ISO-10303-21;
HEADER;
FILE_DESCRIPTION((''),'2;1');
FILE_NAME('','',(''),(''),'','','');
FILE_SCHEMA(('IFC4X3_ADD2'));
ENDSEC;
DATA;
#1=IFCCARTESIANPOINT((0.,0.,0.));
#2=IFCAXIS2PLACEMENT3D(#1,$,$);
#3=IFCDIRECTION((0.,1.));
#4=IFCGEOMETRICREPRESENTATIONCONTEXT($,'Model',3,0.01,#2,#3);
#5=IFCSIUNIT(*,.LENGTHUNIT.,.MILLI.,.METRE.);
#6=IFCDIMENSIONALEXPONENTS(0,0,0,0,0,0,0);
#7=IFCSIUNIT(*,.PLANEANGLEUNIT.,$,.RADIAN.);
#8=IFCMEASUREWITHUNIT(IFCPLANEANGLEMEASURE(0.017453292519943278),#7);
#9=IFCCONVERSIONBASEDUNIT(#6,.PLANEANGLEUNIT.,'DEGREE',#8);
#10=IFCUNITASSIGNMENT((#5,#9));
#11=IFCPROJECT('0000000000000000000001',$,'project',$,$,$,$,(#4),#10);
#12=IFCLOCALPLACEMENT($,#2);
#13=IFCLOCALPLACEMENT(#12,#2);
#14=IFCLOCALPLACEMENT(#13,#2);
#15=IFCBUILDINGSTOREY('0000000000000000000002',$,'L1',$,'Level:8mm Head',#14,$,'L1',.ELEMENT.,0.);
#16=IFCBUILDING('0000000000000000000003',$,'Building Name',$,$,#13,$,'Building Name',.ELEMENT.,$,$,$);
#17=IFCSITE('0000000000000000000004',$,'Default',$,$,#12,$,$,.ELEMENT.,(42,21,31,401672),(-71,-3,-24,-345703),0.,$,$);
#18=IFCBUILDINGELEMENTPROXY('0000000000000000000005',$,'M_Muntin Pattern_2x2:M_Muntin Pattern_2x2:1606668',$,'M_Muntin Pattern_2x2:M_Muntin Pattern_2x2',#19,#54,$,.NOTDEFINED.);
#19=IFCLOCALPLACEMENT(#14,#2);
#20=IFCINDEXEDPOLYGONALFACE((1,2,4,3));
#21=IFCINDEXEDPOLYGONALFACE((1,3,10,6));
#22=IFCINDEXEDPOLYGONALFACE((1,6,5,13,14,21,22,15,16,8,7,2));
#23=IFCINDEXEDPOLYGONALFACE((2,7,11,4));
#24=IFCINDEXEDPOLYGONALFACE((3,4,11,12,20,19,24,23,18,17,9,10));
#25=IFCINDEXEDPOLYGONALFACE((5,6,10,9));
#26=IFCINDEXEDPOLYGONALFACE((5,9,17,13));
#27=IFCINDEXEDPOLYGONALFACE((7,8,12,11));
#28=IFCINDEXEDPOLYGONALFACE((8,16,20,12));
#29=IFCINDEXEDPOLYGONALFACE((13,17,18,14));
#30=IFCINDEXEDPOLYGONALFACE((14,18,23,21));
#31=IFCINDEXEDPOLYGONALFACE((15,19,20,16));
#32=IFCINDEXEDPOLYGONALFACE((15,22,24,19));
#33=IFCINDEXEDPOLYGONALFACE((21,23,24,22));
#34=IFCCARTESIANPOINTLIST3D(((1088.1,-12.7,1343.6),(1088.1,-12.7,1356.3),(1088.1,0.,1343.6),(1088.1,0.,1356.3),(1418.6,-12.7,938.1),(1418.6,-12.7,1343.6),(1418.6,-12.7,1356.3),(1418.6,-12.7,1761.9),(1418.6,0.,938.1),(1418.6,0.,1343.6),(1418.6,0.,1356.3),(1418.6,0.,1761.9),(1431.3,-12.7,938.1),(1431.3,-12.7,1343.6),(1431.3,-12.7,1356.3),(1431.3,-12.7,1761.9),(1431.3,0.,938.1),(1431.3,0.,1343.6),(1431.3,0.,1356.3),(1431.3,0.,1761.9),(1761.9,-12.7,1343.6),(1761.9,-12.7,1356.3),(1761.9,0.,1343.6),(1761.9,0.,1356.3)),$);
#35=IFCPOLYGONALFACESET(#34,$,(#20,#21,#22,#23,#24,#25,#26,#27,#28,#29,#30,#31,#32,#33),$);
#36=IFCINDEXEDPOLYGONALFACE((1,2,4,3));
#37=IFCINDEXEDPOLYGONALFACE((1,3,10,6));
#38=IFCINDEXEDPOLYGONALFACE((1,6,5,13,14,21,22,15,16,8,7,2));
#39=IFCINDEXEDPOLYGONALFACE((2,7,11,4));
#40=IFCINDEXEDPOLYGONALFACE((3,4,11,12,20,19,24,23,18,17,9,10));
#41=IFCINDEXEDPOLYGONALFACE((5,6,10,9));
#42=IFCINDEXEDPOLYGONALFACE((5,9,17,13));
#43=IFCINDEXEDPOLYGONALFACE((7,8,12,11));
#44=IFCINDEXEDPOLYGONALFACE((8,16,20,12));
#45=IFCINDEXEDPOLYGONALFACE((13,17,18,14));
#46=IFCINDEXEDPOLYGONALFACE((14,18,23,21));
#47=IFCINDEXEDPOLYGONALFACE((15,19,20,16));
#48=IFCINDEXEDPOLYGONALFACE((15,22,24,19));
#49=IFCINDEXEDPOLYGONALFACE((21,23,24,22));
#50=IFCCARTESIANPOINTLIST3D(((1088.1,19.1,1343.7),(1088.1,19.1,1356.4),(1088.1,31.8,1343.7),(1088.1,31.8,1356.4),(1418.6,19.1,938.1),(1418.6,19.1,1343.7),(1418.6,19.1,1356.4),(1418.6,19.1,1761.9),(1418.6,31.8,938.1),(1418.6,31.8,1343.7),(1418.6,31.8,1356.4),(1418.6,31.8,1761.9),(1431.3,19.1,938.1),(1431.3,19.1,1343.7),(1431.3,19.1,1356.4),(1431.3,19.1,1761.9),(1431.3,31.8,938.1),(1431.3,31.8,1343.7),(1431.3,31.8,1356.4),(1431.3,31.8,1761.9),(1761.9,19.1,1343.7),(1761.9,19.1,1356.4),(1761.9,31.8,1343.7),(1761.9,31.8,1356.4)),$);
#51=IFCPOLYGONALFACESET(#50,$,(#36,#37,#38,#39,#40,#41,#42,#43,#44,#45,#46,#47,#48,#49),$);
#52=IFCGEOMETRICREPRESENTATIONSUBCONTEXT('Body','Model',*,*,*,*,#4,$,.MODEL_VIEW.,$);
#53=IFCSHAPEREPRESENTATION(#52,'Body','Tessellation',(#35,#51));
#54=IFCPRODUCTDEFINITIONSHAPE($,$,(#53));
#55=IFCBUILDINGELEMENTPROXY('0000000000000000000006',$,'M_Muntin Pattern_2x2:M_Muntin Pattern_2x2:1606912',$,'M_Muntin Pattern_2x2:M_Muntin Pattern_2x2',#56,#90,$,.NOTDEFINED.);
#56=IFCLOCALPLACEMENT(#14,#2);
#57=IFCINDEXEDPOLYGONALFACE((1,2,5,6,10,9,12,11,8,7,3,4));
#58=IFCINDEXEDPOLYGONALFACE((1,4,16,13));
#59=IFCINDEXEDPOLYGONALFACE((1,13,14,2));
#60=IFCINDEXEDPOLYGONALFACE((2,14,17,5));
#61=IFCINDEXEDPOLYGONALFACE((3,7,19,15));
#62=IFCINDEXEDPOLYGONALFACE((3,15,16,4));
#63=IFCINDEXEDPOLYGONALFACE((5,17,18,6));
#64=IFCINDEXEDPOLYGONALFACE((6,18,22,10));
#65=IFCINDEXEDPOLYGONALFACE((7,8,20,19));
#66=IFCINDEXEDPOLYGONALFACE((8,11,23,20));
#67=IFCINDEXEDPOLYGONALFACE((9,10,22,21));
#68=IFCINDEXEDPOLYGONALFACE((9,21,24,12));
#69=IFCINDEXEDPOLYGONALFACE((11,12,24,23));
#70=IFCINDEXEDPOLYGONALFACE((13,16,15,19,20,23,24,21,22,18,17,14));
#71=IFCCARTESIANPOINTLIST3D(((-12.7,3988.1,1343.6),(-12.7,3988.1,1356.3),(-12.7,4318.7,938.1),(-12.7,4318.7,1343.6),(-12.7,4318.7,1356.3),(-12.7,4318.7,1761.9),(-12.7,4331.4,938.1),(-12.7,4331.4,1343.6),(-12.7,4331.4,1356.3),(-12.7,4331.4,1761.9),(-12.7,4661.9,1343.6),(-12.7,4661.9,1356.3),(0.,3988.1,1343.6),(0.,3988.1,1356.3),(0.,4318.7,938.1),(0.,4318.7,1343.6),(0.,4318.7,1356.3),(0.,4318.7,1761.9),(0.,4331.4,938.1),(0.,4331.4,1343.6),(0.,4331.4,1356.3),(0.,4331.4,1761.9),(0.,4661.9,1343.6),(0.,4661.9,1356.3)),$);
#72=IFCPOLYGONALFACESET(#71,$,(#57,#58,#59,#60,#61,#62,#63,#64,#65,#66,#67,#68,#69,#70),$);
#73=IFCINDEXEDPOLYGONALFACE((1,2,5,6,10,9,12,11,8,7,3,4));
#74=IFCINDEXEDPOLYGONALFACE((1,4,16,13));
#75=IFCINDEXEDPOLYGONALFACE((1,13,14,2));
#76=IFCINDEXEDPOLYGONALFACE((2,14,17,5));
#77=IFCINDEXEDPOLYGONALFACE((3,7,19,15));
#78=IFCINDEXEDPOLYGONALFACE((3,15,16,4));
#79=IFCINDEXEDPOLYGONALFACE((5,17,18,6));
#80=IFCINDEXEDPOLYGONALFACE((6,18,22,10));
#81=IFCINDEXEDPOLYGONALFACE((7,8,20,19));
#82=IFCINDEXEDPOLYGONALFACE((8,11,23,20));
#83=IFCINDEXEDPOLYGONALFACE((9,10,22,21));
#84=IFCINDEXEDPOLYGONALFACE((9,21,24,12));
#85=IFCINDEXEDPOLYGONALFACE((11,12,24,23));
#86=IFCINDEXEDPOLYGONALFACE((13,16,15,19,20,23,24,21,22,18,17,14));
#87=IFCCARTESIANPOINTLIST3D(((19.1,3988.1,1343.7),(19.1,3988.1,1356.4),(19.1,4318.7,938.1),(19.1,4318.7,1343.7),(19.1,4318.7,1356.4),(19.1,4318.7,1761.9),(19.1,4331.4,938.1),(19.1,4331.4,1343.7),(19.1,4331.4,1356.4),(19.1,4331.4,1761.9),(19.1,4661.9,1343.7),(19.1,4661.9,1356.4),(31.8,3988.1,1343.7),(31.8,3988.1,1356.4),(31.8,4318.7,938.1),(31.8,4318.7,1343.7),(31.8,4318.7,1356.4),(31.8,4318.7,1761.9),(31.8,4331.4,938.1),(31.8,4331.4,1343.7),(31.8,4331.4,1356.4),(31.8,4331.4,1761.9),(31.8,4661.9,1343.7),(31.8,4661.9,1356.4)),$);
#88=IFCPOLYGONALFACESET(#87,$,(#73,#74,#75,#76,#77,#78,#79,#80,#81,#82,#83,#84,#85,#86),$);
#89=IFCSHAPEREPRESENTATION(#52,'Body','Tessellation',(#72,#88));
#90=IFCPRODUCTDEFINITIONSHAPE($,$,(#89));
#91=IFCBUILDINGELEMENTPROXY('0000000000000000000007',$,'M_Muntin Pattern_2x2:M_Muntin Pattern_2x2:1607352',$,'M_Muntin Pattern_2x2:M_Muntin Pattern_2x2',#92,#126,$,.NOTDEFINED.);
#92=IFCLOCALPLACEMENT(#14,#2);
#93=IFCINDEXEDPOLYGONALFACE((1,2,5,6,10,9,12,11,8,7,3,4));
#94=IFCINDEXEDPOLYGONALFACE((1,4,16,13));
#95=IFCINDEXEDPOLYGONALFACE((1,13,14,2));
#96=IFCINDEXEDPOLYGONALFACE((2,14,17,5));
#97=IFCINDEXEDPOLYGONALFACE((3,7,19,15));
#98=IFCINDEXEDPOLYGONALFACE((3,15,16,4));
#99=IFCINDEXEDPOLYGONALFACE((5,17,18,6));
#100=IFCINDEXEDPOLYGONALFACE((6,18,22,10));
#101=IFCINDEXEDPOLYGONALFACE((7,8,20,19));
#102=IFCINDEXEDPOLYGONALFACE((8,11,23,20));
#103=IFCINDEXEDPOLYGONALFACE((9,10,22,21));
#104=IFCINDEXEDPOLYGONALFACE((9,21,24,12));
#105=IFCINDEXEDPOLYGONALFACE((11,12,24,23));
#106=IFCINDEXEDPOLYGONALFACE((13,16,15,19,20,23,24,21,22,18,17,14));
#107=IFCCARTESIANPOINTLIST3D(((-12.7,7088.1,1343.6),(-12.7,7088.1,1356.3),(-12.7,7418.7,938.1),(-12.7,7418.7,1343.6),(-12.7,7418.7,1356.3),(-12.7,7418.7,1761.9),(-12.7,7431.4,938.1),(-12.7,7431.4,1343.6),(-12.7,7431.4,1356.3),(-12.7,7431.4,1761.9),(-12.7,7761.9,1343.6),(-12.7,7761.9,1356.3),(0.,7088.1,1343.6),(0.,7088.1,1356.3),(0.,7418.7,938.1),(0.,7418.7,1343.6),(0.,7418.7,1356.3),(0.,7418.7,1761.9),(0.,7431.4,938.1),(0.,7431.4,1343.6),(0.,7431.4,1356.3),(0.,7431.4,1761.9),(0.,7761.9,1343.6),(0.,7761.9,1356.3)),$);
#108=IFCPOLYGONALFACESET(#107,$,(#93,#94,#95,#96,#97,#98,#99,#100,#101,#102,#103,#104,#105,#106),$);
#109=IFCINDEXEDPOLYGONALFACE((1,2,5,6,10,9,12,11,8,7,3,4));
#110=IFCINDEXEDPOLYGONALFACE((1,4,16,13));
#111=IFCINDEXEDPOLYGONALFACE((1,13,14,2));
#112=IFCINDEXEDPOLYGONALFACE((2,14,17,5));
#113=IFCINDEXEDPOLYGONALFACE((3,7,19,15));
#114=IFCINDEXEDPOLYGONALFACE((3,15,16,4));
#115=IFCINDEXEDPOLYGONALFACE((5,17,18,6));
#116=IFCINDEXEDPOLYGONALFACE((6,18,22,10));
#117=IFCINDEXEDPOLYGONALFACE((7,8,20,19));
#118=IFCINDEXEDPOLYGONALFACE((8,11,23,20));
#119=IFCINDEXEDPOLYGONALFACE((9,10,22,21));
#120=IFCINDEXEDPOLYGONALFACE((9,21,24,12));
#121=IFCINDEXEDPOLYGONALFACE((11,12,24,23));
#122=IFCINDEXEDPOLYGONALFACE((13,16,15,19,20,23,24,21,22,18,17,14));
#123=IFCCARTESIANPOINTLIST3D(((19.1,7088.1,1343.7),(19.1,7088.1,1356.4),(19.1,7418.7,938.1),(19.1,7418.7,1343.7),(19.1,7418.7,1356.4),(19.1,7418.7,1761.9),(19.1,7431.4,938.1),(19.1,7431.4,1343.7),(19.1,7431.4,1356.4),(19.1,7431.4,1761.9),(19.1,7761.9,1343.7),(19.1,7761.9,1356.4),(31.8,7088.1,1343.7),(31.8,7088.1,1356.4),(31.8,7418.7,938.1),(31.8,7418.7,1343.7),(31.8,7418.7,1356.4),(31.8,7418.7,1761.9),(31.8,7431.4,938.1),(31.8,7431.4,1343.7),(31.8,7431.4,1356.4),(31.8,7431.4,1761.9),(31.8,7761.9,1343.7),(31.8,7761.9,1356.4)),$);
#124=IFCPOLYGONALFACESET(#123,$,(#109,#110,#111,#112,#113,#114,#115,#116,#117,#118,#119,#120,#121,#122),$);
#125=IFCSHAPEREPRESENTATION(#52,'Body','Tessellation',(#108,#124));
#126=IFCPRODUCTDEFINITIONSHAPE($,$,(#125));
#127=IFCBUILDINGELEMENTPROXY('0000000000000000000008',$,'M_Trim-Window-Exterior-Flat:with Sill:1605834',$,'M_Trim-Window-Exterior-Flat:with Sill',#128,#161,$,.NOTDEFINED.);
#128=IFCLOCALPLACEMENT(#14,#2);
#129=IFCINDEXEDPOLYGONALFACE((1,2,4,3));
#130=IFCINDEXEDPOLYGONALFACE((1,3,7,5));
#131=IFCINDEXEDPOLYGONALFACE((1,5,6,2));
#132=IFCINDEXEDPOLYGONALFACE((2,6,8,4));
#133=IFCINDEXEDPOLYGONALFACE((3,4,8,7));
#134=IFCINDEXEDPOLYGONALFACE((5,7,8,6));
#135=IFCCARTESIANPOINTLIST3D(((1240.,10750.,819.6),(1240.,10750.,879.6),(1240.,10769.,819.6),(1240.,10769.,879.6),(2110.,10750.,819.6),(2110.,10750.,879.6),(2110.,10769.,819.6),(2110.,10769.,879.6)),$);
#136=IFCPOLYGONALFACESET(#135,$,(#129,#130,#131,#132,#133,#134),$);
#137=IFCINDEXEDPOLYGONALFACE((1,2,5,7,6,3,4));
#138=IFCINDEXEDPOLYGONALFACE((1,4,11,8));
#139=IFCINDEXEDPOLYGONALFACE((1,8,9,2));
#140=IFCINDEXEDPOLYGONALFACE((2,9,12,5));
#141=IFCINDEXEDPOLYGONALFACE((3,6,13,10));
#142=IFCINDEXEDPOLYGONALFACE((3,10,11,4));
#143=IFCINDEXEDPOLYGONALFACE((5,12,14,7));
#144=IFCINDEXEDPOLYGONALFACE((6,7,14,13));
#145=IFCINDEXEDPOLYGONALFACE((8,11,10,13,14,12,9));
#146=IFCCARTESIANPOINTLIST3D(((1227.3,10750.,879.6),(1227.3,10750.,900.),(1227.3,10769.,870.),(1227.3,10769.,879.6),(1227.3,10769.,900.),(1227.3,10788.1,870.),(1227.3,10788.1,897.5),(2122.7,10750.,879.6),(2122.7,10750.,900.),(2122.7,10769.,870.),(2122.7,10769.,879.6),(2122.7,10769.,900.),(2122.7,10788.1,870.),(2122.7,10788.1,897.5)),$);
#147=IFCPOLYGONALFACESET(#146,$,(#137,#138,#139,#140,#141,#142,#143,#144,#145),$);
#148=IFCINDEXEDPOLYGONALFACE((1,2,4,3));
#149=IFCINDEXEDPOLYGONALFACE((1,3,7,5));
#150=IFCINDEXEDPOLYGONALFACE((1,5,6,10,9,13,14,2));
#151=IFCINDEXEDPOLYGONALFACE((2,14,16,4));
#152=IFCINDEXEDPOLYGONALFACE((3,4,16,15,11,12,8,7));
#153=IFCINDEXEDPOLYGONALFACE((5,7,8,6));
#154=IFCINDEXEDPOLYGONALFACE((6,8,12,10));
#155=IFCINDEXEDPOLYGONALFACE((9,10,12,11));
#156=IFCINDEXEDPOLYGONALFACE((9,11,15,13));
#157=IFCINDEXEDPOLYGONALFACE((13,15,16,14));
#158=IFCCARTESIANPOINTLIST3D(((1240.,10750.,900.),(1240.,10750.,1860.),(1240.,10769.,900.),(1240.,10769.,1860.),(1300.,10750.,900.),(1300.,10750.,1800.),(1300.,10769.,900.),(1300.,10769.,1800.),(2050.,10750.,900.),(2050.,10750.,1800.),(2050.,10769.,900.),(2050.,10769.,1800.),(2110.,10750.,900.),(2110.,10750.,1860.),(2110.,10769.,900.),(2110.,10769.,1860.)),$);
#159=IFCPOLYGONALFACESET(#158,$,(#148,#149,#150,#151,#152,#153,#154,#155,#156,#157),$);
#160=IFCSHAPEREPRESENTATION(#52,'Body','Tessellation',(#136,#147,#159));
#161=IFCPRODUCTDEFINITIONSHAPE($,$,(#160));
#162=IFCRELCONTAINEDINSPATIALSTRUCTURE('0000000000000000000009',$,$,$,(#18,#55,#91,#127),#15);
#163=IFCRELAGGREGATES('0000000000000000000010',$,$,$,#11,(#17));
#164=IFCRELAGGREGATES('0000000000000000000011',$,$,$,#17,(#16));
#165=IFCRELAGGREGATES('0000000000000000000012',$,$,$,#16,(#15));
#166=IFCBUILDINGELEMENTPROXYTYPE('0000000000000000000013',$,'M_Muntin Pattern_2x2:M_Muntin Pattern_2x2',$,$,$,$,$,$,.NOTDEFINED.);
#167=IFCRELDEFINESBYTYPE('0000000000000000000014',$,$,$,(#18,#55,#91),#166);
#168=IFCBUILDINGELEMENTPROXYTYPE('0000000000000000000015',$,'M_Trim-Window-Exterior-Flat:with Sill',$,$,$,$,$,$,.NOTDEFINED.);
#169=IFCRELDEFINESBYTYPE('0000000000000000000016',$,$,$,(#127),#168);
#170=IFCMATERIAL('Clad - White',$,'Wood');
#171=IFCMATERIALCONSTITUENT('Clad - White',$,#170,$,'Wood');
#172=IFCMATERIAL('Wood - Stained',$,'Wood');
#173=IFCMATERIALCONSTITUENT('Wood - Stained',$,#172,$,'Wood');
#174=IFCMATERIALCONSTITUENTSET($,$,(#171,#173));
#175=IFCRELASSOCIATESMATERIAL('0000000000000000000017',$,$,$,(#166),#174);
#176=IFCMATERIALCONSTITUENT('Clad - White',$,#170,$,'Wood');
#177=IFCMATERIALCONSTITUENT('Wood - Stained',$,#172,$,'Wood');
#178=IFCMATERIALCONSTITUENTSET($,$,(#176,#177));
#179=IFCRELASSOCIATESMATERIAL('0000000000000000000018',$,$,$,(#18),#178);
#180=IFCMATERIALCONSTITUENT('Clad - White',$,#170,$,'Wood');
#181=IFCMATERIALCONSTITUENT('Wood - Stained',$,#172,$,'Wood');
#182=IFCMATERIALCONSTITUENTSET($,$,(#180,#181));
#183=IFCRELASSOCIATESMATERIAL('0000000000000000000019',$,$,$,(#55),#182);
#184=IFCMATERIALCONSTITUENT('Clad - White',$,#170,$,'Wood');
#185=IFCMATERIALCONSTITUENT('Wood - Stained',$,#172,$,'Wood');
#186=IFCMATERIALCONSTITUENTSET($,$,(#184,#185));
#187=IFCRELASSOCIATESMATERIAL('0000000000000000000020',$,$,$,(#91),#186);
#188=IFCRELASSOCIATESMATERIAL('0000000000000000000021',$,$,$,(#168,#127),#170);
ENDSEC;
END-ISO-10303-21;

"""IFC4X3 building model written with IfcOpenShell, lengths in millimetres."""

from ifc_helpers import new_model, entity, si_unit, converted_unit, direction, frame, frame_2d, origin, place, context, subcontext, project, spatial, polyline, rectangle, outline, extrude, source, transform, mapped, material, constituent, constituent_set, type_object, type_shapes, element, save


model = new_model("IFC4X3")

# Units and contexts
model_context = context("Model", 3, precision=0.01, world=origin(), true_north=direction((0.0, 1.0)))
body_context = subcontext(model_context, "Body", "Model", "MODEL_VIEW")
ifc_project = project(units=[si_unit("LENGTHUNIT", "METRE", prefix="MILLI"), converted_unit("PLANEANGLEUNIT", "DEGREE", entity("IfcPlaneAngleMeasure", 0.017453292519943278), si_unit("PLANEANGLEUNIT", "RADIAN"), dimensions=[0, 0, 0, 0, 0, 0, 0])], contexts=[model_context])

# Site, building, storey
site_placement = place(None, origin())
site = spatial("IfcSite", under=ifc_project, at=site_placement, Name="Default", CompositionType="ELEMENT", RefLatitude=(42, 21, 31, 401672), RefLongitude=(-71, -3, -24, -345703), RefElevation=0.0)
building_placement = place(site_placement, origin())
building = spatial("IfcBuilding", under=site, at=building_placement, Name="Building Name", LongName="Building Name", CompositionType="ELEMENT")
storey_placement = place(building_placement, origin())
storey = spatial("IfcBuildingStorey", under=building, at=storey_placement, Name="L1", ObjectType="Level:8mm Head", LongName="L1", CompositionType="ELEMENT", Elevation=0.0)

# Building element proxies
ifc_material_1 = material(Name="Clad - White", Category="Wood")
ifc_material_2 = material(Name="Wood - Stained", Category="Wood")
ifc_constituent_1 = constituent(ifc_material_1, Name="Clad - White", Category="Wood")
ifc_constituent_2 = constituent(ifc_material_2, Name="Wood - Stained", Category="Wood")
ifc_constituent_set_1 = constituent_set(constituents=[ifc_constituent_1, ifc_constituent_2])
building_element_proxy_type_1 = type_object("IfcBuildingElementProxyType", Name="M_Muntin Pattern_2x2:M_Muntin Pattern_2x2", PredefinedType="NOTDEFINED", material=ifc_constituent_set_1)
shared_shape_1 = source(origin(), body_context, "Body", "SweptSolid", [
    extrude(outline(polyline([(6.4, -6.4), (411.9, -6.4), (411.9, 6.3), (6.4, 6.3), (6.4, 336.9), (-6.3, 336.9), (-6.3, 6.3), (-411.9, 6.3), (-411.9, -6.4), (-6.3, -6.4), (-6.3, -336.9), (6.4, -336.9), (6.4, -6.4)])), frame((0.0, -22.2, 411.9), z_axis=(0.0, 1.0, 0.0), x_axis=(0.0, 0.0, 1.0)), (0.0, 0.0, 1.0), 12.7),
    extrude(outline(polyline([(6.4, -6.4), (411.9, -6.4), (411.9, 6.3), (6.4, 6.3), (6.4, 336.9), (-6.3, 336.9), (-6.3, 6.3), (-411.9, 6.3), (-411.9, -6.4), (-6.3, -6.4), (-6.3, -336.9), (6.4, -336.9), (6.4, -6.4)])), frame((0.0, 9.5, 411.9), z_axis=(0.0, 1.0, 0.0), x_axis=(0.0, 0.0, 1.0)), (0.0, 0.0, 1.0), 12.7),
])
type_shapes(building_element_proxy_type_1, [shared_shape_1])
ifc_constituent_3 = constituent(ifc_material_1, Name="Clad - White", Category="Wood")
ifc_constituent_4 = constituent(ifc_material_2, Name="Wood - Stained", Category="Wood")
ifc_constituent_set_2 = constituent_set(constituents=[ifc_constituent_3, ifc_constituent_4])
proxy_1_placement = place(storey_placement, frame((1425.0, 9.5, 938.1)))
element("IfcBuildingElementProxy", 1, at=proxy_1_placement, inside=storey, type_object=building_element_proxy_type_1, material=ifc_constituent_set_2, Name="M_Muntin Pattern_2x2:M_Muntin Pattern_2x2:1606668", ObjectType="M_Muntin Pattern_2x2:M_Muntin Pattern_2x2", PredefinedType="NOTDEFINED", context=body_context, shape_type="MappedRepresentation", body=[
    mapped(shared_shape_1, transform((0.0, 0.0, 0.0), scale=1.0)),
])
ifc_constituent_5 = constituent(ifc_material_1, Name="Clad - White", Category="Wood")
ifc_constituent_6 = constituent(ifc_material_2, Name="Wood - Stained", Category="Wood")
ifc_constituent_set_3 = constituent_set(constituents=[ifc_constituent_5, ifc_constituent_6])
proxy_2_placement = place(storey_placement, frame((9.5, 4325.0, 938.1), z_axis=(0.0, 0.0, 1.0), x_axis=(0.0, -1.0, 0.0)))
element("IfcBuildingElementProxy", 2, at=proxy_2_placement, inside=storey, type_object=building_element_proxy_type_1, material=ifc_constituent_set_3, Name="M_Muntin Pattern_2x2:M_Muntin Pattern_2x2:1606912", ObjectType="M_Muntin Pattern_2x2:M_Muntin Pattern_2x2", PredefinedType="NOTDEFINED", context=body_context, shape_type="MappedRepresentation", body=[
    mapped(shared_shape_1, transform((0.0, 0.0, 0.0), scale=1.0)),
])
ifc_constituent_7 = constituent(ifc_material_1, Name="Clad - White", Category="Wood")
ifc_constituent_8 = constituent(ifc_material_2, Name="Wood - Stained", Category="Wood")
ifc_constituent_set_4 = constituent_set(constituents=[ifc_constituent_7, ifc_constituent_8])
proxy_3_placement = place(storey_placement, frame((9.5, 7425.0, 938.1), z_axis=(0.0, 0.0, 1.0), x_axis=(0.0, -1.0, 0.0)))
element("IfcBuildingElementProxy", 3, at=proxy_3_placement, inside=storey, type_object=building_element_proxy_type_1, material=ifc_constituent_set_4, Name="M_Muntin Pattern_2x2:M_Muntin Pattern_2x2:1607352", ObjectType="M_Muntin Pattern_2x2:M_Muntin Pattern_2x2", PredefinedType="NOTDEFINED", context=body_context, shape_type="MappedRepresentation", body=[
    mapped(shared_shape_1, transform((0.0, 0.0, 0.0), scale=1.0)),
])
building_element_proxy_type_2 = type_object("IfcBuildingElementProxyType", Name="M_Trim-Window-Exterior-Flat:with Sill", PredefinedType="NOTDEFINED", material=ifc_material_1)
shared_shape_2 = source(origin(), body_context, "Body", "SweptSolid", [
    extrude(rectangle(XDim=870.0, YDim=60.0, at=frame_2d((0.0, 0.0), x_axis=(1.0, 0.0))), frame((0.0, -950.4, 0.0), z_axis=(0.0, 0.0, 1.0), x_axis=(-1.0, 0.0, 0.0)), (0.0, 0.0, 1.0), 19.0),
    extrude(outline(polyline([(-19.0, -15.2), (0.0, -15.2), (0.0, -5.7), (19.0, -5.7), (19.0, 14.8), (0.0, 14.8), (-19.0, 12.3), (-19.0, -15.2)])), frame((-447.7, -914.8, 19.0), z_axis=(1.0, 0.0, 0.0), x_axis=(0.0, 0.0, -1.0)), (0.0, 0.0, 1.0), 895.4),
    extrude(outline(polyline([(-495.0, -435.0), (465.0, -435.0), (465.0, -375.0), (-435.0, -375.0), (-435.0, 375.0), (465.0, 375.0), (465.0, 435.0), (-495.0, 435.0), (-495.0, -435.0)])), frame((0.0, -435.0, 0.0), z_axis=(0.0, 0.0, 1.0), x_axis=(0.0, -1.0, 0.0)), (0.0, 0.0, 1.0), 19.0),
])
type_shapes(building_element_proxy_type_2, [shared_shape_2])
for number, where, z_axis, x_axis, name in (
    (4, (1675.0, 10750.0, 1800.0), (0.0, 1.0, 0.0), (-1.0, 0.0, 0.0), "M_Trim-Window-Exterior-Flat:with Sill:1605834"),
):
    element("IfcBuildingElementProxy", number, at=place(storey_placement, frame(where, z_axis=z_axis, x_axis=x_axis)), inside=storey, type_object=building_element_proxy_type_2, material=ifc_material_1, Name=name, ObjectType="M_Trim-Window-Exterior-Flat:with Sill", PredefinedType="NOTDEFINED", context=body_context, shape_type="MappedRepresentation", body=[
        mapped(shared_shape_2, transform((0.0, 0.0, 0.0), scale=1.0)),
    ])

save(model, "model.ifc")
